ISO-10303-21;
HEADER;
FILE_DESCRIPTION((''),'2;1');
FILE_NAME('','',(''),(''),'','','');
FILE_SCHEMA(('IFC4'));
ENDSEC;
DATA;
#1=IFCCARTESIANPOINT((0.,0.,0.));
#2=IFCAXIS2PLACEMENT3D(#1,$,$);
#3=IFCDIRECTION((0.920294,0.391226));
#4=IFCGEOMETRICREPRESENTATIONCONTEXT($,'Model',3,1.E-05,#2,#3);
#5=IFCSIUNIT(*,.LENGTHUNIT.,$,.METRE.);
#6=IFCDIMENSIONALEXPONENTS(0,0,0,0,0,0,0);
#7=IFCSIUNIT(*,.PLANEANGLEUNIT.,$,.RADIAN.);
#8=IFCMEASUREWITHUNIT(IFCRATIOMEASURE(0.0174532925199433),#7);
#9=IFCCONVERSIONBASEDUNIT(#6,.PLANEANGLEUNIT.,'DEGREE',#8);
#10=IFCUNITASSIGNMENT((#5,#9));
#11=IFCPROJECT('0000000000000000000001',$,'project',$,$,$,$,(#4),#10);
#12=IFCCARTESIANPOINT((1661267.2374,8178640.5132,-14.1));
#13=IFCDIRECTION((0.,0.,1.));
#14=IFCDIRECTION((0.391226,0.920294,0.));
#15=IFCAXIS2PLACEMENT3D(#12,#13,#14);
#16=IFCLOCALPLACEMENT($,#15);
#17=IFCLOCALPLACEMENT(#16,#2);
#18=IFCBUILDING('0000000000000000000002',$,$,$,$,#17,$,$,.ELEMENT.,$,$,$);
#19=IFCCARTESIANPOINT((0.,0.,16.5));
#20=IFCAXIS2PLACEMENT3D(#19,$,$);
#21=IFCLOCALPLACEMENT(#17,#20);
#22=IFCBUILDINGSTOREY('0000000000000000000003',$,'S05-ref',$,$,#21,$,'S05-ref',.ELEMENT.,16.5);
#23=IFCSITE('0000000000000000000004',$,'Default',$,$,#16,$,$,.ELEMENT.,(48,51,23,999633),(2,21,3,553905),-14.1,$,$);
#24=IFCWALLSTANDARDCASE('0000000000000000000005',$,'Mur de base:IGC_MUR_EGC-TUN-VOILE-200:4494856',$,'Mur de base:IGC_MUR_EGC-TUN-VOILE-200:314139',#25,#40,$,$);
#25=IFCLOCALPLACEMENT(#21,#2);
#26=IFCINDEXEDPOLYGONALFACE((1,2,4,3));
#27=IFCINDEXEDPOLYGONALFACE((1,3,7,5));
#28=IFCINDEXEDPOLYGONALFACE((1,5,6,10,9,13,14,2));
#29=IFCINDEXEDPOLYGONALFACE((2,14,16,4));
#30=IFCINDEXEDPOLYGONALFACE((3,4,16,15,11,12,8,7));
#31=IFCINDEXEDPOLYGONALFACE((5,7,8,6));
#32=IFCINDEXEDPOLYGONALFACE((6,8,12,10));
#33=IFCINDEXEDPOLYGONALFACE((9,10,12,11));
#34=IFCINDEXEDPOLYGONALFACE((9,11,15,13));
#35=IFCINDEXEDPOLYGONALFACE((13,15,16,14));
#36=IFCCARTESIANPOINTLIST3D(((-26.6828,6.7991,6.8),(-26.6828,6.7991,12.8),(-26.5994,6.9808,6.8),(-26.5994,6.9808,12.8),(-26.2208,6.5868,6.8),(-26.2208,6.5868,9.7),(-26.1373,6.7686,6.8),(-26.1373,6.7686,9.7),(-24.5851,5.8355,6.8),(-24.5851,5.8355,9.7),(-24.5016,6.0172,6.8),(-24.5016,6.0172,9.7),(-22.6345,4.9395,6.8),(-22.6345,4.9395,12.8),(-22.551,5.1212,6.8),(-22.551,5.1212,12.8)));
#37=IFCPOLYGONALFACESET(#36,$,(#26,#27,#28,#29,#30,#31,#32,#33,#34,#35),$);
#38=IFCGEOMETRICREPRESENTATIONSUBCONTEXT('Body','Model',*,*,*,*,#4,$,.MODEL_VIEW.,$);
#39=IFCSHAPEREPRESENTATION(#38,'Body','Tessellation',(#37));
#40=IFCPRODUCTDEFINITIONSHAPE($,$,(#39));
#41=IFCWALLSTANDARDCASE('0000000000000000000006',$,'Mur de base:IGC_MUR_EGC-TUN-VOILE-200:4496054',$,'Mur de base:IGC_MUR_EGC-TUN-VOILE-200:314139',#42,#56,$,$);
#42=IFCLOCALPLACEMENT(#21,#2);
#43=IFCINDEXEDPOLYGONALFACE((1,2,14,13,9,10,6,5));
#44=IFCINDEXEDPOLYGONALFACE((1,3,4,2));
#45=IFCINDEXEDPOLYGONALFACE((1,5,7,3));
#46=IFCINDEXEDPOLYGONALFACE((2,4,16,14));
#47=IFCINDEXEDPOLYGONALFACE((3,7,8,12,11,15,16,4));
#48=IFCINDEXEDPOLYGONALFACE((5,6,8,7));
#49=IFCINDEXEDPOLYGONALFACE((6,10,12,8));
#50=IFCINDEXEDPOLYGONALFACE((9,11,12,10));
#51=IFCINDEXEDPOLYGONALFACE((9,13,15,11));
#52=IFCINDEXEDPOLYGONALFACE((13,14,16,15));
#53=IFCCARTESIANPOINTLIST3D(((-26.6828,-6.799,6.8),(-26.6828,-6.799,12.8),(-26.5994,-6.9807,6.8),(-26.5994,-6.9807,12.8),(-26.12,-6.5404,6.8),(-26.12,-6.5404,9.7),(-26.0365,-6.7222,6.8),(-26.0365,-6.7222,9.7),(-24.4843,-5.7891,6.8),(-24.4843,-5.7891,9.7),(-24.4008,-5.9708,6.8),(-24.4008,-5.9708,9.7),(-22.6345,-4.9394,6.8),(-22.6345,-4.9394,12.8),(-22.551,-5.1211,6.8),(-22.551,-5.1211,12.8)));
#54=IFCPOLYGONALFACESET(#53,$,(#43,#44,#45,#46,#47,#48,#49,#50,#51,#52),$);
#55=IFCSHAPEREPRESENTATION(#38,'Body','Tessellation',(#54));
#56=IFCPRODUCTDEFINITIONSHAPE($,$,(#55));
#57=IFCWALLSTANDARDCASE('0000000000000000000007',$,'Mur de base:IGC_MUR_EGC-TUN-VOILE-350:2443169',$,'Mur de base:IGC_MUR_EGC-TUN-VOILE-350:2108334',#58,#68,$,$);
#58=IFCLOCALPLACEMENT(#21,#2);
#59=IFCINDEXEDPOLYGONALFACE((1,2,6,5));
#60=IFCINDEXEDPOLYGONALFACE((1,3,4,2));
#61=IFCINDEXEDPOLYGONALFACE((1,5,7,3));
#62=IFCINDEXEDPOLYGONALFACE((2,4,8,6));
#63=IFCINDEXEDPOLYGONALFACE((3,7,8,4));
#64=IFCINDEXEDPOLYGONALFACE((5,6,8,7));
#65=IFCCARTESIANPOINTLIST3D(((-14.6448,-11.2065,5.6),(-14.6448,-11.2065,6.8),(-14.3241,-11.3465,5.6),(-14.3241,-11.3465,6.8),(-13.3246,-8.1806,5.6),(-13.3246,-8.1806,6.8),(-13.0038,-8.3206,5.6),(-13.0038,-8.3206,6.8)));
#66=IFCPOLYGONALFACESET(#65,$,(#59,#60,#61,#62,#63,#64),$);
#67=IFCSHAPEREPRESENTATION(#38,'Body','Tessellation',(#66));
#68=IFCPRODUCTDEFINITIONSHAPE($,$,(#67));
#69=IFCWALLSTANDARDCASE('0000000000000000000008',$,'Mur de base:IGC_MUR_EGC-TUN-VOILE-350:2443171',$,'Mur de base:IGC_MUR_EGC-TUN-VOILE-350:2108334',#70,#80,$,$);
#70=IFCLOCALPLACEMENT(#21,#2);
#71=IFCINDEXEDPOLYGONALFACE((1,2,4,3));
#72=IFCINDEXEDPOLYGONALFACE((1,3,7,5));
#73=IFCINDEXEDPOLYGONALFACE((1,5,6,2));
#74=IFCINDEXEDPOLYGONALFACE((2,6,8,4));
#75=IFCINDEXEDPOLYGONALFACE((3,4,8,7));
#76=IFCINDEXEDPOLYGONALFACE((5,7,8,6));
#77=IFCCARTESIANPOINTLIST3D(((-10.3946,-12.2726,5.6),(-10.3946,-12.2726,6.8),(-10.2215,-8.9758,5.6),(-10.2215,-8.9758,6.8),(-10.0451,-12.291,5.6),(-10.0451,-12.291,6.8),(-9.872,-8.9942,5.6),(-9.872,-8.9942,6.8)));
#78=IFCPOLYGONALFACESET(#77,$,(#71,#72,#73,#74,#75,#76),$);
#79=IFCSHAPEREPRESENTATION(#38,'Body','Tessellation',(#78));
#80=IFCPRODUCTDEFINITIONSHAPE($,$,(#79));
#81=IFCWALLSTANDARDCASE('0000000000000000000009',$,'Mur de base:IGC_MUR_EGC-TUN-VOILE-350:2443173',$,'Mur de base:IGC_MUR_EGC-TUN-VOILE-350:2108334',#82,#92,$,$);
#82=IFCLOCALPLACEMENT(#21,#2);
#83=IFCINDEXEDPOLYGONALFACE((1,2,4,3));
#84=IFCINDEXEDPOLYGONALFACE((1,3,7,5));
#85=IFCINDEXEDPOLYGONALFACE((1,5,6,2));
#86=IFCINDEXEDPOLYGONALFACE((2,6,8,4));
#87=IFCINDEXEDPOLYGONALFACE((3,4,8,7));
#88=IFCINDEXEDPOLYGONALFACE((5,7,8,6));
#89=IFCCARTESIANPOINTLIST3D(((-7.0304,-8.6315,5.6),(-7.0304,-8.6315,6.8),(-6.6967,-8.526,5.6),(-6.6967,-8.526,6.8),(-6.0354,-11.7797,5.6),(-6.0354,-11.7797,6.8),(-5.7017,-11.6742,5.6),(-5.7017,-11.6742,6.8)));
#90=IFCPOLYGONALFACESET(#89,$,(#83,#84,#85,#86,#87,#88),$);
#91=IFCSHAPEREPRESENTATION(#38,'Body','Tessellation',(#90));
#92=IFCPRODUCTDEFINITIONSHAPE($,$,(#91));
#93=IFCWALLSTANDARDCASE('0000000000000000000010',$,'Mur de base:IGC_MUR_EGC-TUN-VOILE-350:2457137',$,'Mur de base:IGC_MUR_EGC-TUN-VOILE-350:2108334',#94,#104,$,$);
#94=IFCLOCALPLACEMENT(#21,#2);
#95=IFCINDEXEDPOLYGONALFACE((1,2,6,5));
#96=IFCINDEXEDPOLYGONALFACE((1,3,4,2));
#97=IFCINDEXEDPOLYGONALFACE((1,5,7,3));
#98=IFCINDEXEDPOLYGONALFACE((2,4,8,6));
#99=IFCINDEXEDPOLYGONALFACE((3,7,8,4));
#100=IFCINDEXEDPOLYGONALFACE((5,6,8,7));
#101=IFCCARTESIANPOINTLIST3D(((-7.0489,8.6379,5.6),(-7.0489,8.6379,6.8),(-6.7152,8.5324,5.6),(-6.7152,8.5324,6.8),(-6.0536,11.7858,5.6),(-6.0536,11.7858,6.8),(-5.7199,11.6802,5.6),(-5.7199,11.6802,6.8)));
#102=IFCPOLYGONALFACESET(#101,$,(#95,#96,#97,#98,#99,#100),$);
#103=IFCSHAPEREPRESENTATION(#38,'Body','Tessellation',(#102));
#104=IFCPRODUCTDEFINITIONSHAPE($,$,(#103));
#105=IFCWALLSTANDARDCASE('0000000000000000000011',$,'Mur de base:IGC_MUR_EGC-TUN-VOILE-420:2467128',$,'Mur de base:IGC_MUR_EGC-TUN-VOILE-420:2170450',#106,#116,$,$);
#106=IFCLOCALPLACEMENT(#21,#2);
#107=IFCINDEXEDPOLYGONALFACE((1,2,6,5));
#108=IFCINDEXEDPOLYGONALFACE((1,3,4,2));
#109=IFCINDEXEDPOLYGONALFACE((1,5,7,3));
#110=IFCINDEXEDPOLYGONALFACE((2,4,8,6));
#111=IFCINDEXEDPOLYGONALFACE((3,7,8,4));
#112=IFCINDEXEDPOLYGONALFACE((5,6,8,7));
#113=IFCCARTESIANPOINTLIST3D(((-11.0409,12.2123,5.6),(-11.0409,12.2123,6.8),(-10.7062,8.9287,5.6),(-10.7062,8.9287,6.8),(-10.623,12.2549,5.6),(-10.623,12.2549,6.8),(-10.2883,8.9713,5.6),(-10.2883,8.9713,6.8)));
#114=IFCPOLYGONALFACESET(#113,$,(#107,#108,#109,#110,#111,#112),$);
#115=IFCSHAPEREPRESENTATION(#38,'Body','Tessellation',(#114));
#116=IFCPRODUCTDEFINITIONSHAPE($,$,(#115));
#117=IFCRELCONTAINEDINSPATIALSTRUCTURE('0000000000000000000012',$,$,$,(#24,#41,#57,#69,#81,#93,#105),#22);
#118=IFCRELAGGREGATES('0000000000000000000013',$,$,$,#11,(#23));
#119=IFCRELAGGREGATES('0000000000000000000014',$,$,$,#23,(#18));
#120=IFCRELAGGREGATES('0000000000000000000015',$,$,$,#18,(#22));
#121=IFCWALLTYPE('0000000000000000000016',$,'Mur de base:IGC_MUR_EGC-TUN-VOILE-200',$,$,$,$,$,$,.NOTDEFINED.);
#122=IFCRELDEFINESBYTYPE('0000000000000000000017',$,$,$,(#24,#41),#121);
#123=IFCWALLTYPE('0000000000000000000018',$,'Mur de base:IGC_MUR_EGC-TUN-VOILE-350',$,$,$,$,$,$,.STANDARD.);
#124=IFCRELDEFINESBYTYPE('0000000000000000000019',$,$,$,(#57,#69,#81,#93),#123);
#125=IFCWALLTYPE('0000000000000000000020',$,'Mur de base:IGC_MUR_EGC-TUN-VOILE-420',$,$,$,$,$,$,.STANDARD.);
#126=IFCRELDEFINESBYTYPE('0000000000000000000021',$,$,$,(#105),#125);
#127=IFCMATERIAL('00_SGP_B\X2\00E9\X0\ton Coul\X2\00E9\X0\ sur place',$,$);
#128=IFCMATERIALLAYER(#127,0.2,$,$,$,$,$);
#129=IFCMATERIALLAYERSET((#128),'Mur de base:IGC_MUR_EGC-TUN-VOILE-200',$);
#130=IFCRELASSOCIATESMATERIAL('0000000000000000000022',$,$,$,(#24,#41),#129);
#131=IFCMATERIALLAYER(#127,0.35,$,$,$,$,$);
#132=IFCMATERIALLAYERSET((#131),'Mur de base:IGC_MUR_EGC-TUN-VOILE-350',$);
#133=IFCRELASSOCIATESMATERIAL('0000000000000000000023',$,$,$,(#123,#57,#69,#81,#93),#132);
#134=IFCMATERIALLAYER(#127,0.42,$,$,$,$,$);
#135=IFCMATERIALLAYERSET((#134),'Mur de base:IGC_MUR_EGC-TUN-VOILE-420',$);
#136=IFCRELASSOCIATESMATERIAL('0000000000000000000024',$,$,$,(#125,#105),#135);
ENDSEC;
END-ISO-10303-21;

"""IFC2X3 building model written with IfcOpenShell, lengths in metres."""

from ifc_helpers import new_model, entity, si_unit, converted_unit, direction, frame, frame_2d, origin, place, context, subcontext, project, spatial, rectangle, extrude, material, layer, layer_set, layer_usage, type_object, element, save


model = new_model("IFC2X3")

# Units and contexts
model_context = context("Model", 3, precision=1e-05, world=origin(), true_north=direction((0.920294, 0.391226)))
body_context = subcontext(model_context, "Body", "Model", "MODEL_VIEW")
ifc_project = project(units=[si_unit("LENGTHUNIT", "METRE"), converted_unit("PLANEANGLEUNIT", "DEGREE", entity("IfcRatioMeasure", 0.0174532925199433), si_unit("PLANEANGLEUNIT", "RADIAN"), dimensions=[0, 0, 0, 0, 0, 0, 0])], contexts=[model_context])

# Site, building, storey
site_placement = place(None, frame((1661267.2374, 8178640.5132, -14.1), z_axis=(0.0, 0.0, 1.0), x_axis=(0.391226, 0.920294, 0.0)))
site = spatial("IfcSite", under=ifc_project, at=site_placement, Name="Default", CompositionType="ELEMENT", RefLatitude=(48, 51, 23, 999633), RefLongitude=(2, 21, 3, 553905), RefElevation=-14.1)
building_placement = place(site_placement, origin())
building = spatial("IfcBuilding", under=site, at=building_placement, CompositionType="ELEMENT")
storey_placement = place(building_placement, frame((0.0, 0.0, 16.5)))
storey = spatial("IfcBuildingStorey", under=building, at=storey_placement, Name="S05-ref", LongName="S05-ref", CompositionType="ELEMENT", Elevation=16.5)

# Shared definitions
ifc_material_1 = material(Name="00_SGP_Béton Coulé sur place")

# Shared definitions
ifc_layer_1 = layer(ifc_material_1, 0.2)
ifc_layer_set_1 = layer_set([ifc_layer_1], Name="Mur de base:IGC_MUR_EGC-TUN-VOILE-200")
wall_type_1 = type_object("IfcWallType", Name="Mur de base:IGC_MUR_EGC-TUN-VOILE-200", PredefinedType="NOTDEFINED")

# Walls, openings
ifc_layer_usage_1 = layer_usage(ifc_layer_set_1, "AXIS2", "POSITIVE", -0.1)
wall_1_placement = place(storey_placement, frame((-22.5927, 5.0303, 6.8), z_axis=(0.0, 0.0, 1.0), x_axis=(-0.908714, 0.417419, 0.0)))
wall_1 = element("IfcWallStandardCase", 1, at=wall_1_placement, inside=storey, type_object=wall_type_1, material=ifc_layer_usage_1, Name="Mur de base:IGC_MUR_EGC-TUN-VOILE-200:4494856", ObjectType="Mur de base:IGC_MUR_EGC-TUN-VOILE-200:314139", context=body_context, shape_type="SweptSolid", body=[
    extrude(rectangle(XDim=4.455, YDim=0.2, at=frame_2d((2.2275, 0.0), x_axis=(-1.0, 0.0))), origin(), (0.0, 0.0, 1.0), 6.0),
])
opening_1_placement = place(wall_1_placement, origin())
element("IfcOpeningElement", 2, at=opening_1_placement, cuts=wall_1, ObjectType="Opening", context=body_context, shape_type="SweptSolid", body=[
    extrude(rectangle(XDim=2.9, YDim=1.8, at=frame_2d((0.0, 0.0), x_axis=(1.0, 0.0))), frame((3.0466, -1.424, 1.45), z_axis=(0.0, 1.0, 0.0), x_axis=(0.0, 0.0, -1.0)), (0.0, 0.0, 1.0), 3.048),
])
ifc_layer_usage_2 = layer_usage(ifc_layer_set_1, "AXIS2", "NEGATIVE", 0.1)
wall_2_placement = place(storey_placement, frame((-22.5927, -5.0302, 6.8), z_axis=(0.0, 0.0, 1.0), x_axis=(-0.908712, -0.417423, 0.0)))
wall_2 = element("IfcWallStandardCase", 3, at=wall_2_placement, inside=storey, type_object=wall_type_1, material=ifc_layer_usage_2, Name="Mur de base:IGC_MUR_EGC-TUN-VOILE-200:4496054", ObjectType="Mur de base:IGC_MUR_EGC-TUN-VOILE-200:314139", context=body_context, shape_type="SweptSolid", body=[
    extrude(rectangle(XDim=4.455, YDim=0.2, at=frame_2d((2.2275, 0.0), x_axis=(-1.0, 0.0))), origin(), (0.0, 0.0, 1.0), 6.0),
])
opening_2_placement = place(wall_2_placement, origin())
element("IfcOpeningElement", 4, at=opening_2_placement, cuts=wall_2, ObjectType="Opening", context=body_context, shape_type="SweptSolid", body=[
    extrude(rectangle(XDim=2.9, YDim=1.8, at=frame_2d((0.0, 0.0), x_axis=(0.0, 1.0))), frame((2.9357, -1.624, 1.45), z_axis=(0.0, 1.0, 0.0), x_axis=(1.0, 0.0, 0.0)), (0.0, 0.0, 1.0), 3.048),
])

# Walls
ifc_layer_2 = layer(ifc_material_1, 0.35)
ifc_layer_set_2 = layer_set([ifc_layer_2], Name="Mur de base:IGC_MUR_EGC-TUN-VOILE-350")
wall_type_2 = type_object("IfcWallType", Name="Mur de base:IGC_MUR_EGC-TUN-VOILE-350", PredefinedType="STANDARD", material=ifc_layer_set_2)
ifc_layer_usage_3 = layer_usage(ifc_layer_set_2, "AXIS2", "POSITIVE", -0.175)
wall_3_placement = place(storey_placement, frame((-13.1642, -8.2506, 5.6), z_axis=(0.0, 0.0, 1.0), x_axis=(-0.39991, -0.916554, 0.0)))
element("IfcWallStandardCase", 5, at=wall_3_placement, inside=storey, type_object=wall_type_2, material=ifc_layer_usage_3, Name="Mur de base:IGC_MUR_EGC-TUN-VOILE-350:2443169", ObjectType="Mur de base:IGC_MUR_EGC-TUN-VOILE-350:2108334", context=body_context, shape_type="SweptSolid", body=[
    extrude(rectangle(XDim=3.3014, YDim=0.35, at=frame_2d((1.6507, 0.0), x_axis=(-1.0, 0.0))), origin(), (0.0, 0.0, 1.0), 1.2),
])
ifc_layer_usage_4 = layer_usage(ifc_layer_set_2, "AXIS2", "POSITIVE", -0.175)
wall_4_placement = place(storey_placement, frame((-10.0468, -8.985, 5.6), z_axis=(0.0, 0.0, 1.0), x_axis=(-0.052435, -0.998624, 0.0)))
element("IfcWallStandardCase", 6, at=wall_4_placement, inside=storey, type_object=wall_type_2, material=ifc_layer_usage_4, Name="Mur de base:IGC_MUR_EGC-TUN-VOILE-350:2443171", ObjectType="Mur de base:IGC_MUR_EGC-TUN-VOILE-350:2108334", context=body_context, shape_type="SweptSolid", body=[
    extrude(rectangle(XDim=3.3014, YDim=0.35, at=frame_2d((1.6507, 0.0), x_axis=(-1.0, 0.0))), origin(), (0.0, 0.0, 1.0), 1.2),
])
ifc_layer_usage_5 = layer_usage(ifc_layer_set_2, "AXIS2", "POSITIVE", -0.175)
wall_5_placement = place(storey_placement, frame((-6.8636, -8.5787, 5.6), z_axis=(0.0, 0.0, 1.0), x_axis=(0.301365, -0.953509, 0.0)))
element("IfcWallStandardCase", 7, at=wall_5_placement, inside=storey, type_object=wall_type_2, material=ifc_layer_usage_5, Name="Mur de base:IGC_MUR_EGC-TUN-VOILE-350:2443173", ObjectType="Mur de base:IGC_MUR_EGC-TUN-VOILE-350:2108334", context=body_context, shape_type="SweptSolid", body=[
    extrude(rectangle(XDim=3.3017, YDim=0.35, at=frame_2d((1.6508, 0.0), x_axis=(-1.0, 0.0))), origin(), (0.0, 0.0, 1.0), 1.2),
])
ifc_layer_usage_6 = layer_usage(ifc_layer_set_2, "AXIS2", "POSITIVE", -0.175)
wall_6_placement = place(storey_placement, frame((-6.8821, 8.5851, 5.6), z_axis=(0.0, 0.0, 1.0), x_axis=(0.301469, 0.953476, 0.0)))
element("IfcWallStandardCase", 8, at=wall_6_placement, inside=storey, type_object=wall_type_2, material=ifc_layer_usage_6, Name="Mur de base:IGC_MUR_EGC-TUN-VOILE-350:2457137", ObjectType="Mur de base:IGC_MUR_EGC-TUN-VOILE-350:2108334", context=body_context, shape_type="SweptSolid", body=[
    extrude(rectangle(XDim=3.3015, YDim=0.35, at=frame_2d((1.6507, 0.0), x_axis=(-1.0, 0.0))), origin(), (0.0, 0.0, 1.0), 1.2),
])
ifc_layer_3 = layer(ifc_material_1, 0.42)
ifc_layer_set_3 = layer_set([ifc_layer_3], Name="Mur de base:IGC_MUR_EGC-TUN-VOILE-420")
ifc_layer_usage_7 = layer_usage(ifc_layer_set_3, "AXIS2", "POSITIVE", -0.21)
wall_type_3 = type_object("IfcWallType", Name="Mur de base:IGC_MUR_EGC-TUN-VOILE-420", PredefinedType="STANDARD", material=ifc_layer_set_3)
wall_7_placement = place(storey_placement, frame((-10.4973, 8.95, 5.6), z_axis=(0.0, 0.0, 1.0), x_axis=(-0.101398, 0.994846, 0.0)))
element("IfcWallStandardCase", 9, at=wall_7_placement, inside=storey, type_object=wall_type_3, material=ifc_layer_usage_7, Name="Mur de base:IGC_MUR_EGC-TUN-VOILE-420:2467128", ObjectType="Mur de base:IGC_MUR_EGC-TUN-VOILE-420:2170450", context=body_context, shape_type="SweptSolid", body=[
    extrude(rectangle(XDim=3.3006, YDim=0.42, at=frame_2d((1.6503, 0.0), x_axis=(-1.0, 0.0))), origin(), (0.0, 0.0, 1.0), 1.2),
])

save(model, "model.ifc")
